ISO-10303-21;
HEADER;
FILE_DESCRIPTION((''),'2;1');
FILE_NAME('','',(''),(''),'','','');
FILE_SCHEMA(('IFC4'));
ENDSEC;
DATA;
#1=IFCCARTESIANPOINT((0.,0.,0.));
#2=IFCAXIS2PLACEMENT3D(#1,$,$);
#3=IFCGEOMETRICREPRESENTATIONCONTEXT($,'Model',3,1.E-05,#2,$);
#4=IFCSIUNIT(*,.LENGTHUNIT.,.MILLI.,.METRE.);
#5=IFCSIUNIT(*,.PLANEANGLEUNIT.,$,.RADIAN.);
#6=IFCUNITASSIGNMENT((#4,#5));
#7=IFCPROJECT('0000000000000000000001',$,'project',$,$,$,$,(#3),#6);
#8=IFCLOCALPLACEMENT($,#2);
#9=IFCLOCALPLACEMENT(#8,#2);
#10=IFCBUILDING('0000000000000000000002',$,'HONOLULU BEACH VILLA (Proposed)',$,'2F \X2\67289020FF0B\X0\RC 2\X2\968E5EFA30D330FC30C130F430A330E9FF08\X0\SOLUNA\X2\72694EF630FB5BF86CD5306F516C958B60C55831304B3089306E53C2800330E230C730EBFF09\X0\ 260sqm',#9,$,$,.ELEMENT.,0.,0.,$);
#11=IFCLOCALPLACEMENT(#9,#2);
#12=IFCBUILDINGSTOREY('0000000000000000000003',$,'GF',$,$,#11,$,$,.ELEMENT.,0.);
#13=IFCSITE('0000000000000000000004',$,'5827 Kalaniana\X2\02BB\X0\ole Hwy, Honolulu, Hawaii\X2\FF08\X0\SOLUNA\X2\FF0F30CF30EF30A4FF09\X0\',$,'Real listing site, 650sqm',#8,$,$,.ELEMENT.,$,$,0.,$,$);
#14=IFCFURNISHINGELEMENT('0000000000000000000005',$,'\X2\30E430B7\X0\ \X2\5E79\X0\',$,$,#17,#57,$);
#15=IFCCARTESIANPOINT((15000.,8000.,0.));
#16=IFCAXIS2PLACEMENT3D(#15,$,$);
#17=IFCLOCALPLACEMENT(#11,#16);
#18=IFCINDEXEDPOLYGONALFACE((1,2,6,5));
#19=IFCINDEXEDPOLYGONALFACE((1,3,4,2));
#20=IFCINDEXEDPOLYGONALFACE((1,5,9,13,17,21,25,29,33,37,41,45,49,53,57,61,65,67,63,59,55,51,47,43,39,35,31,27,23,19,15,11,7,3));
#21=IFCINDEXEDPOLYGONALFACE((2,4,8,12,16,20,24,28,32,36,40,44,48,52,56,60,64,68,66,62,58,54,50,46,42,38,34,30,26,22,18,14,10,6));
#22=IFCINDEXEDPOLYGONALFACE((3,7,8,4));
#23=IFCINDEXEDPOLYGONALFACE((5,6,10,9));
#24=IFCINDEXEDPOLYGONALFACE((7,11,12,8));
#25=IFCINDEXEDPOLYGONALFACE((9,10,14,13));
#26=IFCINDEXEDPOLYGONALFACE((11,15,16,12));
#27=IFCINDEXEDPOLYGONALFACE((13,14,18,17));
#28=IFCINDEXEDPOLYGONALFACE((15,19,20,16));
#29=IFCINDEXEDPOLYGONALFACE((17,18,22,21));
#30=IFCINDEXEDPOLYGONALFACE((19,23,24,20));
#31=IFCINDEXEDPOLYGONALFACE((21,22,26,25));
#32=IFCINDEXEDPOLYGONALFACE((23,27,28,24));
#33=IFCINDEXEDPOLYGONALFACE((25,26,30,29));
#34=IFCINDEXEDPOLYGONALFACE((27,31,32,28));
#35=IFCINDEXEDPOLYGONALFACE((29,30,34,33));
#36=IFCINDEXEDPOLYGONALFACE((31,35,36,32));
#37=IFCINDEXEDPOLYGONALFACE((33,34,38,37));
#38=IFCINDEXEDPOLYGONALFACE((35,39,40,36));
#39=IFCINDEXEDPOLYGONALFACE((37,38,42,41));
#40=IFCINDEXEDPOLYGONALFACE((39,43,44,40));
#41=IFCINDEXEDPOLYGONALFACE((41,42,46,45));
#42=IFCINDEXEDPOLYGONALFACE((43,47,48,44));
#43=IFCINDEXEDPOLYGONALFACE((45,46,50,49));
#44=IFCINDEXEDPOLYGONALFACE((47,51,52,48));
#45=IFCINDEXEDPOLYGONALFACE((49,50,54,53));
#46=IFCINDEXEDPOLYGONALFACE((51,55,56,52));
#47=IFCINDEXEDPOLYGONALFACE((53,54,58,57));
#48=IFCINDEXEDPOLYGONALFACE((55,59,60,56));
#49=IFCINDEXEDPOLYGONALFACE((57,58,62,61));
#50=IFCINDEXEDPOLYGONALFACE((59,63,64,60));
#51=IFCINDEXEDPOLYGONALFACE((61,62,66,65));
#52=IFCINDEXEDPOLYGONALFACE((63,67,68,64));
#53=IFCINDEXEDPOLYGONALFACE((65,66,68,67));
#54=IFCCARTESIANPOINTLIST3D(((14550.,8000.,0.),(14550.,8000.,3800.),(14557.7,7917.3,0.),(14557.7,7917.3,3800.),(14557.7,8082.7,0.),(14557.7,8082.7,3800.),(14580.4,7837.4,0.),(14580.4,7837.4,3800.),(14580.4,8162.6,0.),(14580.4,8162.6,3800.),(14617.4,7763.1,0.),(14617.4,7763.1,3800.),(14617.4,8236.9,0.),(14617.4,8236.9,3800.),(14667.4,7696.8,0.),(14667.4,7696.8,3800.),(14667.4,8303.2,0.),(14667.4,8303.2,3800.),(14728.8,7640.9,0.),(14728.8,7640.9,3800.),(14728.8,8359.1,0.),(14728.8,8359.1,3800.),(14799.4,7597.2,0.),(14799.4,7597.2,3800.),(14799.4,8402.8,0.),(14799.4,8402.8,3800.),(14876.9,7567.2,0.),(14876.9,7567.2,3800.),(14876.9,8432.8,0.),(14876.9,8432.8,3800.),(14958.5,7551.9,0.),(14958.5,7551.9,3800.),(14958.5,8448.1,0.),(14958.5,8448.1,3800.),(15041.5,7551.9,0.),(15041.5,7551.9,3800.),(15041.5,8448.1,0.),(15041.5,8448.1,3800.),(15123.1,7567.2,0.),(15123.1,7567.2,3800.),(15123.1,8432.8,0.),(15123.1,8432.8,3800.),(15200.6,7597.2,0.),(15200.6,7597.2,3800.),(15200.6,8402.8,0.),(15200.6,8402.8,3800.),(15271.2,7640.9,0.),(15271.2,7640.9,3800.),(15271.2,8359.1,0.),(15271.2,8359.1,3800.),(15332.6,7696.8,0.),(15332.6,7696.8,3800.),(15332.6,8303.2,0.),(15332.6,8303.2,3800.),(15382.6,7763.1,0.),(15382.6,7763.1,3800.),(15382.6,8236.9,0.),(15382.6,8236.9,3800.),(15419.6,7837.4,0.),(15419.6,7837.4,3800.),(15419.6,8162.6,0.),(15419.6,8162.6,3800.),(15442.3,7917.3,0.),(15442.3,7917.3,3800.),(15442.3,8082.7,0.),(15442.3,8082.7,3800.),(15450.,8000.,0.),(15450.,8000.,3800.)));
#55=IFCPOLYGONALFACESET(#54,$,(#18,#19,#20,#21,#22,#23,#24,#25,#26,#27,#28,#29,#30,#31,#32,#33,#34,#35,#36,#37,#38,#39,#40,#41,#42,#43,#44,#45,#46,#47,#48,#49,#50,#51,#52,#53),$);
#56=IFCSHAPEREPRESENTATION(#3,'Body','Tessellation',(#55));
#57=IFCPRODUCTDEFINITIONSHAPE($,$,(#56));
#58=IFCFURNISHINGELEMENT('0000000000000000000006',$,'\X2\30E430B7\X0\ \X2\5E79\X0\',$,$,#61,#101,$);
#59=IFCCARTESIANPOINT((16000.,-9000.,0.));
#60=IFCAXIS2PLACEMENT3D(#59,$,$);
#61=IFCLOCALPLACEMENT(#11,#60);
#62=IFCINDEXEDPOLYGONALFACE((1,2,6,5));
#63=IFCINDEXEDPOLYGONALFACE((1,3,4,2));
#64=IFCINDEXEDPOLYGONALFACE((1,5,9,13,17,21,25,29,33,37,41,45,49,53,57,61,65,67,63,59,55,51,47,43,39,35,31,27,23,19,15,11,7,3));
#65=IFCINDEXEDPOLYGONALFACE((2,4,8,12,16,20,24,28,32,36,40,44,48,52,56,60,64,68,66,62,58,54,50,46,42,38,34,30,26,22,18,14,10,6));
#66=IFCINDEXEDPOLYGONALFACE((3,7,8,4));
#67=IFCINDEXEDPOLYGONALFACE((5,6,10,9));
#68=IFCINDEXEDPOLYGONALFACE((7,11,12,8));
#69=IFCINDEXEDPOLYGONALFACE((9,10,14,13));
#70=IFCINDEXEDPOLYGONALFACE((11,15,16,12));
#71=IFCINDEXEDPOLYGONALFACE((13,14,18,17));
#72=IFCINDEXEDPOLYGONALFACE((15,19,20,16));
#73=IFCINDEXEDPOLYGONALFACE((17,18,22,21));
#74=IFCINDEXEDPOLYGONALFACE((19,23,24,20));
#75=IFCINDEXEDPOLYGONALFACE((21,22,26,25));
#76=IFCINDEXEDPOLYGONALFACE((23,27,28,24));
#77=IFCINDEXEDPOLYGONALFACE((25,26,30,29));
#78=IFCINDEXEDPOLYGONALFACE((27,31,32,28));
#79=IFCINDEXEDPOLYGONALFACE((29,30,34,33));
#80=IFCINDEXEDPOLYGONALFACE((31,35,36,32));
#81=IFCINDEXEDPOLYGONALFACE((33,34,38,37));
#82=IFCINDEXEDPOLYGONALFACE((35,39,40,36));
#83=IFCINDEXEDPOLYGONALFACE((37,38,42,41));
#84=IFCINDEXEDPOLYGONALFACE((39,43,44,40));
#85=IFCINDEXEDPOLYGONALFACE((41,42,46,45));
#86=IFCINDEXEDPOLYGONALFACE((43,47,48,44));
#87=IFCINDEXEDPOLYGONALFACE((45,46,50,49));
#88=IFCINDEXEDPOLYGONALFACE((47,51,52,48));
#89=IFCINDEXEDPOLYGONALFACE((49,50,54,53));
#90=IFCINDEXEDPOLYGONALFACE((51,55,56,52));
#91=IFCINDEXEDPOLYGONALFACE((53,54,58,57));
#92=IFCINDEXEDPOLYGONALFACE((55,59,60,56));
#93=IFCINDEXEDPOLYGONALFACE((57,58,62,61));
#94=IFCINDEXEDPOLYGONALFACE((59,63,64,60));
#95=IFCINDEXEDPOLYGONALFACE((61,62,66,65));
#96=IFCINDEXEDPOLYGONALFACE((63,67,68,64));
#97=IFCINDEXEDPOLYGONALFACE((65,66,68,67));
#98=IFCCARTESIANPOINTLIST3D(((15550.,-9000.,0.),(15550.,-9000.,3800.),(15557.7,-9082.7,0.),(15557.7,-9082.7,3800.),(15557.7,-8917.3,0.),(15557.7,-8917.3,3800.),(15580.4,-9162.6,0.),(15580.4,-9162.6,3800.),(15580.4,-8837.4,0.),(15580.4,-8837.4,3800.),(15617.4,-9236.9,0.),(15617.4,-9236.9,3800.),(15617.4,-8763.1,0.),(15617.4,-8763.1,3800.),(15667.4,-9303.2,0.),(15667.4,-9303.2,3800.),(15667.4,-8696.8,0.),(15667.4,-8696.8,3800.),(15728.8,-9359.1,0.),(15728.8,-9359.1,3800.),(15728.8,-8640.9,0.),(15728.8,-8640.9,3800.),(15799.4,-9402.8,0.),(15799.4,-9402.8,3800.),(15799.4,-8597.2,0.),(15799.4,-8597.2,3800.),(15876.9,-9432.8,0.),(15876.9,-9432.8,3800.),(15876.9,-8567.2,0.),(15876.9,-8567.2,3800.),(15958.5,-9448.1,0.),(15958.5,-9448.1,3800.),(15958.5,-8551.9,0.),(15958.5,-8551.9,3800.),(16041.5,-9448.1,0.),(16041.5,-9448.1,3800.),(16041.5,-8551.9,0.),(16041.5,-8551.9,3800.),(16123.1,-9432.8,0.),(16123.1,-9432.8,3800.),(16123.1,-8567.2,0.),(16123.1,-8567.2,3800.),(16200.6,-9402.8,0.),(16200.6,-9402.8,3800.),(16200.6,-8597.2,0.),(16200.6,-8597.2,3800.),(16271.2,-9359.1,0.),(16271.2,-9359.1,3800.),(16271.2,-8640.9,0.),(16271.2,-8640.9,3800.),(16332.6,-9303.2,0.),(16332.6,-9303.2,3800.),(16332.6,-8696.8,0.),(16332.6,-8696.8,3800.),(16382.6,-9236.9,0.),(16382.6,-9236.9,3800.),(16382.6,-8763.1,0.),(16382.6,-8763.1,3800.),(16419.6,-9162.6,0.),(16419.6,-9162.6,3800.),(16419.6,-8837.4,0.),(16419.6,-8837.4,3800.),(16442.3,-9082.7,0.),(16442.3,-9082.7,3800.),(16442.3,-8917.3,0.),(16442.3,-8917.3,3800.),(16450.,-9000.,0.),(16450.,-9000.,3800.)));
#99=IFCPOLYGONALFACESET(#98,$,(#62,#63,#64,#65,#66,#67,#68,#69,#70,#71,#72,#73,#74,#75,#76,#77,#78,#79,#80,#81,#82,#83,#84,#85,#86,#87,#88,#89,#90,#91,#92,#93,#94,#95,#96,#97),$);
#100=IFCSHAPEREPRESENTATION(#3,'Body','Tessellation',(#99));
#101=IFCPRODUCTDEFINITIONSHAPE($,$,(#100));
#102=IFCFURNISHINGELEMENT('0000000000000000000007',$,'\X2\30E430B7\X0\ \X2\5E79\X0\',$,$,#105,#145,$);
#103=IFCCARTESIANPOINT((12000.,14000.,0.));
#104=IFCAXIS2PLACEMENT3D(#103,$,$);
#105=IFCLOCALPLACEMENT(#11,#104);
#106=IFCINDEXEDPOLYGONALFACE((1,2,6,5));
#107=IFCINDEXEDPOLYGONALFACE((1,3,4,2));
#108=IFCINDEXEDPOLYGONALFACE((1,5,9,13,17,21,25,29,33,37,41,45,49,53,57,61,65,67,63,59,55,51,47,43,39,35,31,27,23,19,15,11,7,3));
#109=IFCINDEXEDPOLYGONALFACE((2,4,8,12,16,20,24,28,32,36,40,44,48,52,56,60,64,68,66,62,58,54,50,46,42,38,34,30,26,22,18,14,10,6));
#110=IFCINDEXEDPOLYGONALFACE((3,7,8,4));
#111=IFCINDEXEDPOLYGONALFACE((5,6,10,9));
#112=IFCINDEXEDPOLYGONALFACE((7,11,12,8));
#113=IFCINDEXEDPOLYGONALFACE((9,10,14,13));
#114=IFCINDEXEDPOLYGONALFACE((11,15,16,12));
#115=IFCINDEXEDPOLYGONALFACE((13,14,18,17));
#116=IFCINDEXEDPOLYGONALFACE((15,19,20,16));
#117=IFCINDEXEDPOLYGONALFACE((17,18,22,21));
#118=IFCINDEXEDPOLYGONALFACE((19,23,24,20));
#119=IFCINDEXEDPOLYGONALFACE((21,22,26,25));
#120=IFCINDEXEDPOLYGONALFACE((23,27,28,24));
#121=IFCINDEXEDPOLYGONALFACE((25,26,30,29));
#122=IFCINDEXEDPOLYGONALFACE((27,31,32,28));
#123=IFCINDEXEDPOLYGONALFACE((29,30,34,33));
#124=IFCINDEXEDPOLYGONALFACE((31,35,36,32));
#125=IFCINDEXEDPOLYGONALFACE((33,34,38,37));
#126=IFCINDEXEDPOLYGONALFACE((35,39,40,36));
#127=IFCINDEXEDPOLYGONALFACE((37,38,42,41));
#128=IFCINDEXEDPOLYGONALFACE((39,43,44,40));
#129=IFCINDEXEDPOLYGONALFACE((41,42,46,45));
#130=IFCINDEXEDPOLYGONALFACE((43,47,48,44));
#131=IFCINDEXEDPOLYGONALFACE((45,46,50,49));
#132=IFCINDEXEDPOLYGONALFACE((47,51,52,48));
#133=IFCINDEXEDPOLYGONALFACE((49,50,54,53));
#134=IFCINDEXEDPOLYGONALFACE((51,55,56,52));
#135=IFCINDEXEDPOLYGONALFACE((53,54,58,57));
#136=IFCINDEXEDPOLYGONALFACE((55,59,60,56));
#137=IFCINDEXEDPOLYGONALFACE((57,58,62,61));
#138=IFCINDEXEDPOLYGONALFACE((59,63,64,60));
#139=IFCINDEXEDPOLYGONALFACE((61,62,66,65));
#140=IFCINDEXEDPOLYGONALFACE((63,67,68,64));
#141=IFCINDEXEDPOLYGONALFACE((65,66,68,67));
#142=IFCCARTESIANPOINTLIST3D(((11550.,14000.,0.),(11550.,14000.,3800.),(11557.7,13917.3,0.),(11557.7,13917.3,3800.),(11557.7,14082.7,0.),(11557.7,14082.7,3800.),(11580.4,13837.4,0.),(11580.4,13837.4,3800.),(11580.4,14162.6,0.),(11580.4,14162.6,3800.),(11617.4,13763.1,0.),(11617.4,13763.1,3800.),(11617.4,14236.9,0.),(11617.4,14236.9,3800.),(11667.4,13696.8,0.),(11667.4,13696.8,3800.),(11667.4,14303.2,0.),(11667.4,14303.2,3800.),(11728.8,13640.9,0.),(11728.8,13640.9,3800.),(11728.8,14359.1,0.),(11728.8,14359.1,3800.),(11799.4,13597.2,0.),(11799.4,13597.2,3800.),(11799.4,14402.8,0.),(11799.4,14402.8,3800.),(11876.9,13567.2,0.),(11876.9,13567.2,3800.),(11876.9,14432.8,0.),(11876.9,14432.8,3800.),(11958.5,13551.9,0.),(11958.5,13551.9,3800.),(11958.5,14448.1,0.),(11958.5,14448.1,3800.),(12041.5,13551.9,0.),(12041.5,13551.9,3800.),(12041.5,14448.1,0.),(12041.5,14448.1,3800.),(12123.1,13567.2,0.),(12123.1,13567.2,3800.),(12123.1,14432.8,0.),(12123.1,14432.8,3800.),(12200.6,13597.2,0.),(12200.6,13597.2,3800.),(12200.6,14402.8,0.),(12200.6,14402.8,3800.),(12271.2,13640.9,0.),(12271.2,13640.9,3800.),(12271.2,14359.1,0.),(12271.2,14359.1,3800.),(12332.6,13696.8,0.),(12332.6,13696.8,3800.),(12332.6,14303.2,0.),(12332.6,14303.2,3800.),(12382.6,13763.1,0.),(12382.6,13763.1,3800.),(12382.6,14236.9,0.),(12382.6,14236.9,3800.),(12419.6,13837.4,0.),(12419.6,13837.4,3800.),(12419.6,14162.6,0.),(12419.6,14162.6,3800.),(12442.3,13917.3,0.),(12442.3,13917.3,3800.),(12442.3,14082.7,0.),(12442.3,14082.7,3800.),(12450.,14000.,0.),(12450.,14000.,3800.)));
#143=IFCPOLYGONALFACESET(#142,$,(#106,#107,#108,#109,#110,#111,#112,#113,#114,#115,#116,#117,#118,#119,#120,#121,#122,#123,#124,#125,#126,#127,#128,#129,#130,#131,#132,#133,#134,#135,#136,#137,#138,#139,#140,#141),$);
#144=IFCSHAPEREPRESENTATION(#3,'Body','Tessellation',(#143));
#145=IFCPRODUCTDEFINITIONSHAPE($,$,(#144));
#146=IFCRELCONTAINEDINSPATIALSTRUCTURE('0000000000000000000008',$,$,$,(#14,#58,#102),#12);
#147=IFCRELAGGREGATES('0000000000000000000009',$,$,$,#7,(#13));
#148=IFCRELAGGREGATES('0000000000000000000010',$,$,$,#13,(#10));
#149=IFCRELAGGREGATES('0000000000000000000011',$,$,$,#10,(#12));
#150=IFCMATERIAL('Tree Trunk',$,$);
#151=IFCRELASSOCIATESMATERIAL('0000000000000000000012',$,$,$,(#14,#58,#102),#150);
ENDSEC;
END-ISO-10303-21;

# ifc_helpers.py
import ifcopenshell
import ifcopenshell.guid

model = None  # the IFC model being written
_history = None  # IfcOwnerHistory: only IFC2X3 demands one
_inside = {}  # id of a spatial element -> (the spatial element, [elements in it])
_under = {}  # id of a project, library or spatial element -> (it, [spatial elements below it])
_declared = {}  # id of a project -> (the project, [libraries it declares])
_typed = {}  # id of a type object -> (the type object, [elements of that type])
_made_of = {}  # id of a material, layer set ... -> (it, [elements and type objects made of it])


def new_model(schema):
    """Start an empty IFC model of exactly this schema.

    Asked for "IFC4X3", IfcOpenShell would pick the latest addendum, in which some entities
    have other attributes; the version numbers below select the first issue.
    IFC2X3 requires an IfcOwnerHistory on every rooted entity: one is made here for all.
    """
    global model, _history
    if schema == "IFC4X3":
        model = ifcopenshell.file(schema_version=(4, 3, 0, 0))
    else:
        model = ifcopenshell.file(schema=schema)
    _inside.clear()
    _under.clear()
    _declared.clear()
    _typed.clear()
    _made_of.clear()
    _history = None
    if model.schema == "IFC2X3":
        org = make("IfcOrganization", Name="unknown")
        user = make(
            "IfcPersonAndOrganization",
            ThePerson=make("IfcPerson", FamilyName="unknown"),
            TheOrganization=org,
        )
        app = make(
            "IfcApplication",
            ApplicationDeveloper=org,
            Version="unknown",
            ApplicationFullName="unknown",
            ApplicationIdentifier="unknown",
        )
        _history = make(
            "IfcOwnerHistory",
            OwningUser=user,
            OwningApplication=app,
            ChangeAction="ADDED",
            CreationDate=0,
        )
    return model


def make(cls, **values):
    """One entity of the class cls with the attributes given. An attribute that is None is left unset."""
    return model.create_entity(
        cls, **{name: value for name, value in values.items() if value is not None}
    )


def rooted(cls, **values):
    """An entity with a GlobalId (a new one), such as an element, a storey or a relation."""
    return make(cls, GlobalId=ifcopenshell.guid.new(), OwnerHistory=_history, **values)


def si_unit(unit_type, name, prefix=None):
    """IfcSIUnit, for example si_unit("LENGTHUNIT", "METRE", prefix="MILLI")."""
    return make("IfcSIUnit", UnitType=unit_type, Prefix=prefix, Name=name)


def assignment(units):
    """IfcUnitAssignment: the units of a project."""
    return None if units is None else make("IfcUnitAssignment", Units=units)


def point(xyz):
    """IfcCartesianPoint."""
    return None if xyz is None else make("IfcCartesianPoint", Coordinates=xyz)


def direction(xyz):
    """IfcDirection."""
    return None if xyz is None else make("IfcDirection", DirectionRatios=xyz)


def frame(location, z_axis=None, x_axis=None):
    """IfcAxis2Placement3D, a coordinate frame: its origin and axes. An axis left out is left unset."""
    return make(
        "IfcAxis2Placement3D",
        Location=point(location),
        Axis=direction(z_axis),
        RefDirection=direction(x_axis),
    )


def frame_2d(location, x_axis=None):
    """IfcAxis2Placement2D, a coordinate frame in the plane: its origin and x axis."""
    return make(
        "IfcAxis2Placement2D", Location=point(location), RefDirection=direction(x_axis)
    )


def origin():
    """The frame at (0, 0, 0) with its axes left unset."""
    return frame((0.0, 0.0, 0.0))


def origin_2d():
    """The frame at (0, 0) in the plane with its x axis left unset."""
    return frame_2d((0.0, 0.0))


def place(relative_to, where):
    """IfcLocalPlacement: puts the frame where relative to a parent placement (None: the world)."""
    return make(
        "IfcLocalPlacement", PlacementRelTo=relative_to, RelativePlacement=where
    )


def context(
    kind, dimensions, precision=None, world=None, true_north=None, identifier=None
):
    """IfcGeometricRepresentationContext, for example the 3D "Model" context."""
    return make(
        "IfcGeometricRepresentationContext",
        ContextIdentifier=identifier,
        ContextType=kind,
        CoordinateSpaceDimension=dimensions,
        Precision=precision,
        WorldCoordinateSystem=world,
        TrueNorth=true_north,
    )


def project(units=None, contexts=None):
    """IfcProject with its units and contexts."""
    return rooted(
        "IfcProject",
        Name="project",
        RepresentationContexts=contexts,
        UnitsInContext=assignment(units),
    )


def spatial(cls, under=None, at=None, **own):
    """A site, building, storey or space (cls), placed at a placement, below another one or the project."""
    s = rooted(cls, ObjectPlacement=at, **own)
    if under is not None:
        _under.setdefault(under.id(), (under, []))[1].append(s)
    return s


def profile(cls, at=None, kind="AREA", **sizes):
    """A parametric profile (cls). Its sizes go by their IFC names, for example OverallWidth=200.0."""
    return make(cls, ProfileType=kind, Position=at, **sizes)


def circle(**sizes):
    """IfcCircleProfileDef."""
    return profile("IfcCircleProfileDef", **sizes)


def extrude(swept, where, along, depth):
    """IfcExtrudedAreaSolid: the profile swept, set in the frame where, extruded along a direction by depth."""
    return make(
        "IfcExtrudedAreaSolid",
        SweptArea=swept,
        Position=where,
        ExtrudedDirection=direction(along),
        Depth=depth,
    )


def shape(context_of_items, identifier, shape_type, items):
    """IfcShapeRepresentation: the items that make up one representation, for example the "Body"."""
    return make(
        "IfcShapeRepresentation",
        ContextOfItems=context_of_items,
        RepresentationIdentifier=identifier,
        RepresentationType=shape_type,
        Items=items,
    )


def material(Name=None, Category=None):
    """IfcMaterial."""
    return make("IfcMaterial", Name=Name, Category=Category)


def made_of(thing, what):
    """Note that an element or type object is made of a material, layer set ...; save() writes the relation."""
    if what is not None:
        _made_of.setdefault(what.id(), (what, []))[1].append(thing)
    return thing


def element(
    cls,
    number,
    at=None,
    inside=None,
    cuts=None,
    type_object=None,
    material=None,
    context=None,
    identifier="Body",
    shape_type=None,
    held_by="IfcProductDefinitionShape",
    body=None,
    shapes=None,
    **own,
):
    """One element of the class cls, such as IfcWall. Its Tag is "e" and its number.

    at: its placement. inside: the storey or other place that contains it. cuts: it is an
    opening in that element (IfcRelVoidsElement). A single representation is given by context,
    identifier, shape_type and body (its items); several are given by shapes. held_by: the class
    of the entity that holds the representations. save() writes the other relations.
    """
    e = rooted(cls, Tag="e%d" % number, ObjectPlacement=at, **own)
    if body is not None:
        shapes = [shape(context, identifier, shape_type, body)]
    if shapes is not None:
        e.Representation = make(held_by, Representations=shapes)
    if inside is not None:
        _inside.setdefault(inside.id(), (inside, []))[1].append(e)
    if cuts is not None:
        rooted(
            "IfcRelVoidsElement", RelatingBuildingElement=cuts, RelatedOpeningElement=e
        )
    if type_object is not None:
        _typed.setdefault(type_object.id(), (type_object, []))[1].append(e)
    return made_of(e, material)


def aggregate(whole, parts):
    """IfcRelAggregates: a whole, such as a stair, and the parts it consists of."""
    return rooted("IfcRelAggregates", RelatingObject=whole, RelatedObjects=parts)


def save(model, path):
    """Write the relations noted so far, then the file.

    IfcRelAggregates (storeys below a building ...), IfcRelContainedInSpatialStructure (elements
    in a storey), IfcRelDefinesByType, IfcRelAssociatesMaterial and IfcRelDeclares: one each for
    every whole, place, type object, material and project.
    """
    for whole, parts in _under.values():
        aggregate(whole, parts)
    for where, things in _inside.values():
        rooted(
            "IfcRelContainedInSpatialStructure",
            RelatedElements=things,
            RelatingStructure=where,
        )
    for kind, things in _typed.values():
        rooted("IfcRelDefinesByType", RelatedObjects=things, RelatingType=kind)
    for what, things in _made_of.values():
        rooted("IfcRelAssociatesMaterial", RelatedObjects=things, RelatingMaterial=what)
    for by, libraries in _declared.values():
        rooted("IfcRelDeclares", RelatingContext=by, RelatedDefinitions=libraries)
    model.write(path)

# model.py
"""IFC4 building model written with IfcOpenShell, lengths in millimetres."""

from ifc_helpers import new_model, si_unit, frame, origin, origin_2d, place, context, project, spatial, circle, extrude, material, element, save


model = new_model("IFC4")

# Units and contexts
model_context = context("Model", 3, precision=1e-05, world=origin())
ifc_project = project(units=[si_unit("LENGTHUNIT", "METRE", prefix="MILLI"), si_unit("PLANEANGLEUNIT", "RADIAN")], contexts=[model_context])

# Site, building, storey
site_placement = place(None, origin())
site = spatial("IfcSite", under=ifc_project, at=site_placement, Name="5827 Kalanianaʻole Hwy, Honolulu, Hawaii（SOLUNA／ハワイ）", ObjectType="Real listing site, 650sqm", CompositionType="ELEMENT", RefElevation=0.0)
building_placement = place(site_placement, origin())
building = spatial("IfcBuilding", under=site, at=building_placement, Name="HONOLULU BEACH VILLA (Proposed)", ObjectType="2F 木造＋RC 2階建ビーチヴィラ（SOLUNA物件・寸法は公開情報からの参考モデル） 260sqm", CompositionType="ELEMENT", ElevationOfRefHeight=0.0, ElevationOfTerrain=0.0)
storey_placement = place(building_placement, origin())
storey = spatial("IfcBuildingStorey", under=building, at=storey_placement, Name="GF", CompositionType="ELEMENT", Elevation=0.0)

# Furnishing elements
ifc_material_1 = material(Name="Tree Trunk")
furnishing_1_placement = place(storey_placement, frame((15000.0, 8000.0, 0.0)))
element("IfcFurnishingElement", 1, at=furnishing_1_placement, inside=storey, material=ifc_material_1, Name="ヤシ 幹", context=model_context, shape_type="SweptSolid", body=[
    extrude(circle(Radius=450.0, at=origin_2d()), frame((15000.0, 8000.0, 0.0)), (0.0, 0.0, 1.0), 3800.0),
])
furnishing_2_placement = place(storey_placement, frame((16000.0, -9000.0, 0.0)))
element("IfcFurnishingElement", 2, at=furnishing_2_placement, inside=storey, material=ifc_material_1, Name="ヤシ 幹", context=model_context, shape_type="SweptSolid", body=[
    extrude(circle(Radius=450.0, at=origin_2d()), frame((16000.0, -9000.0, 0.0)), (0.0, 0.0, 1.0), 3800.0),
])
furnishing_3_placement = place(storey_placement, frame((12000.0, 14000.0, 0.0)))
element("IfcFurnishingElement", 3, at=furnishing_3_placement, inside=storey, material=ifc_material_1, Name="ヤシ 幹", context=model_context, shape_type="SweptSolid", body=[
    extrude(circle(Radius=450.0, at=origin_2d()), frame((12000.0, 14000.0, 0.0)), (0.0, 0.0, 1.0), 3800.0),
])

save(model, "model.ifc")
